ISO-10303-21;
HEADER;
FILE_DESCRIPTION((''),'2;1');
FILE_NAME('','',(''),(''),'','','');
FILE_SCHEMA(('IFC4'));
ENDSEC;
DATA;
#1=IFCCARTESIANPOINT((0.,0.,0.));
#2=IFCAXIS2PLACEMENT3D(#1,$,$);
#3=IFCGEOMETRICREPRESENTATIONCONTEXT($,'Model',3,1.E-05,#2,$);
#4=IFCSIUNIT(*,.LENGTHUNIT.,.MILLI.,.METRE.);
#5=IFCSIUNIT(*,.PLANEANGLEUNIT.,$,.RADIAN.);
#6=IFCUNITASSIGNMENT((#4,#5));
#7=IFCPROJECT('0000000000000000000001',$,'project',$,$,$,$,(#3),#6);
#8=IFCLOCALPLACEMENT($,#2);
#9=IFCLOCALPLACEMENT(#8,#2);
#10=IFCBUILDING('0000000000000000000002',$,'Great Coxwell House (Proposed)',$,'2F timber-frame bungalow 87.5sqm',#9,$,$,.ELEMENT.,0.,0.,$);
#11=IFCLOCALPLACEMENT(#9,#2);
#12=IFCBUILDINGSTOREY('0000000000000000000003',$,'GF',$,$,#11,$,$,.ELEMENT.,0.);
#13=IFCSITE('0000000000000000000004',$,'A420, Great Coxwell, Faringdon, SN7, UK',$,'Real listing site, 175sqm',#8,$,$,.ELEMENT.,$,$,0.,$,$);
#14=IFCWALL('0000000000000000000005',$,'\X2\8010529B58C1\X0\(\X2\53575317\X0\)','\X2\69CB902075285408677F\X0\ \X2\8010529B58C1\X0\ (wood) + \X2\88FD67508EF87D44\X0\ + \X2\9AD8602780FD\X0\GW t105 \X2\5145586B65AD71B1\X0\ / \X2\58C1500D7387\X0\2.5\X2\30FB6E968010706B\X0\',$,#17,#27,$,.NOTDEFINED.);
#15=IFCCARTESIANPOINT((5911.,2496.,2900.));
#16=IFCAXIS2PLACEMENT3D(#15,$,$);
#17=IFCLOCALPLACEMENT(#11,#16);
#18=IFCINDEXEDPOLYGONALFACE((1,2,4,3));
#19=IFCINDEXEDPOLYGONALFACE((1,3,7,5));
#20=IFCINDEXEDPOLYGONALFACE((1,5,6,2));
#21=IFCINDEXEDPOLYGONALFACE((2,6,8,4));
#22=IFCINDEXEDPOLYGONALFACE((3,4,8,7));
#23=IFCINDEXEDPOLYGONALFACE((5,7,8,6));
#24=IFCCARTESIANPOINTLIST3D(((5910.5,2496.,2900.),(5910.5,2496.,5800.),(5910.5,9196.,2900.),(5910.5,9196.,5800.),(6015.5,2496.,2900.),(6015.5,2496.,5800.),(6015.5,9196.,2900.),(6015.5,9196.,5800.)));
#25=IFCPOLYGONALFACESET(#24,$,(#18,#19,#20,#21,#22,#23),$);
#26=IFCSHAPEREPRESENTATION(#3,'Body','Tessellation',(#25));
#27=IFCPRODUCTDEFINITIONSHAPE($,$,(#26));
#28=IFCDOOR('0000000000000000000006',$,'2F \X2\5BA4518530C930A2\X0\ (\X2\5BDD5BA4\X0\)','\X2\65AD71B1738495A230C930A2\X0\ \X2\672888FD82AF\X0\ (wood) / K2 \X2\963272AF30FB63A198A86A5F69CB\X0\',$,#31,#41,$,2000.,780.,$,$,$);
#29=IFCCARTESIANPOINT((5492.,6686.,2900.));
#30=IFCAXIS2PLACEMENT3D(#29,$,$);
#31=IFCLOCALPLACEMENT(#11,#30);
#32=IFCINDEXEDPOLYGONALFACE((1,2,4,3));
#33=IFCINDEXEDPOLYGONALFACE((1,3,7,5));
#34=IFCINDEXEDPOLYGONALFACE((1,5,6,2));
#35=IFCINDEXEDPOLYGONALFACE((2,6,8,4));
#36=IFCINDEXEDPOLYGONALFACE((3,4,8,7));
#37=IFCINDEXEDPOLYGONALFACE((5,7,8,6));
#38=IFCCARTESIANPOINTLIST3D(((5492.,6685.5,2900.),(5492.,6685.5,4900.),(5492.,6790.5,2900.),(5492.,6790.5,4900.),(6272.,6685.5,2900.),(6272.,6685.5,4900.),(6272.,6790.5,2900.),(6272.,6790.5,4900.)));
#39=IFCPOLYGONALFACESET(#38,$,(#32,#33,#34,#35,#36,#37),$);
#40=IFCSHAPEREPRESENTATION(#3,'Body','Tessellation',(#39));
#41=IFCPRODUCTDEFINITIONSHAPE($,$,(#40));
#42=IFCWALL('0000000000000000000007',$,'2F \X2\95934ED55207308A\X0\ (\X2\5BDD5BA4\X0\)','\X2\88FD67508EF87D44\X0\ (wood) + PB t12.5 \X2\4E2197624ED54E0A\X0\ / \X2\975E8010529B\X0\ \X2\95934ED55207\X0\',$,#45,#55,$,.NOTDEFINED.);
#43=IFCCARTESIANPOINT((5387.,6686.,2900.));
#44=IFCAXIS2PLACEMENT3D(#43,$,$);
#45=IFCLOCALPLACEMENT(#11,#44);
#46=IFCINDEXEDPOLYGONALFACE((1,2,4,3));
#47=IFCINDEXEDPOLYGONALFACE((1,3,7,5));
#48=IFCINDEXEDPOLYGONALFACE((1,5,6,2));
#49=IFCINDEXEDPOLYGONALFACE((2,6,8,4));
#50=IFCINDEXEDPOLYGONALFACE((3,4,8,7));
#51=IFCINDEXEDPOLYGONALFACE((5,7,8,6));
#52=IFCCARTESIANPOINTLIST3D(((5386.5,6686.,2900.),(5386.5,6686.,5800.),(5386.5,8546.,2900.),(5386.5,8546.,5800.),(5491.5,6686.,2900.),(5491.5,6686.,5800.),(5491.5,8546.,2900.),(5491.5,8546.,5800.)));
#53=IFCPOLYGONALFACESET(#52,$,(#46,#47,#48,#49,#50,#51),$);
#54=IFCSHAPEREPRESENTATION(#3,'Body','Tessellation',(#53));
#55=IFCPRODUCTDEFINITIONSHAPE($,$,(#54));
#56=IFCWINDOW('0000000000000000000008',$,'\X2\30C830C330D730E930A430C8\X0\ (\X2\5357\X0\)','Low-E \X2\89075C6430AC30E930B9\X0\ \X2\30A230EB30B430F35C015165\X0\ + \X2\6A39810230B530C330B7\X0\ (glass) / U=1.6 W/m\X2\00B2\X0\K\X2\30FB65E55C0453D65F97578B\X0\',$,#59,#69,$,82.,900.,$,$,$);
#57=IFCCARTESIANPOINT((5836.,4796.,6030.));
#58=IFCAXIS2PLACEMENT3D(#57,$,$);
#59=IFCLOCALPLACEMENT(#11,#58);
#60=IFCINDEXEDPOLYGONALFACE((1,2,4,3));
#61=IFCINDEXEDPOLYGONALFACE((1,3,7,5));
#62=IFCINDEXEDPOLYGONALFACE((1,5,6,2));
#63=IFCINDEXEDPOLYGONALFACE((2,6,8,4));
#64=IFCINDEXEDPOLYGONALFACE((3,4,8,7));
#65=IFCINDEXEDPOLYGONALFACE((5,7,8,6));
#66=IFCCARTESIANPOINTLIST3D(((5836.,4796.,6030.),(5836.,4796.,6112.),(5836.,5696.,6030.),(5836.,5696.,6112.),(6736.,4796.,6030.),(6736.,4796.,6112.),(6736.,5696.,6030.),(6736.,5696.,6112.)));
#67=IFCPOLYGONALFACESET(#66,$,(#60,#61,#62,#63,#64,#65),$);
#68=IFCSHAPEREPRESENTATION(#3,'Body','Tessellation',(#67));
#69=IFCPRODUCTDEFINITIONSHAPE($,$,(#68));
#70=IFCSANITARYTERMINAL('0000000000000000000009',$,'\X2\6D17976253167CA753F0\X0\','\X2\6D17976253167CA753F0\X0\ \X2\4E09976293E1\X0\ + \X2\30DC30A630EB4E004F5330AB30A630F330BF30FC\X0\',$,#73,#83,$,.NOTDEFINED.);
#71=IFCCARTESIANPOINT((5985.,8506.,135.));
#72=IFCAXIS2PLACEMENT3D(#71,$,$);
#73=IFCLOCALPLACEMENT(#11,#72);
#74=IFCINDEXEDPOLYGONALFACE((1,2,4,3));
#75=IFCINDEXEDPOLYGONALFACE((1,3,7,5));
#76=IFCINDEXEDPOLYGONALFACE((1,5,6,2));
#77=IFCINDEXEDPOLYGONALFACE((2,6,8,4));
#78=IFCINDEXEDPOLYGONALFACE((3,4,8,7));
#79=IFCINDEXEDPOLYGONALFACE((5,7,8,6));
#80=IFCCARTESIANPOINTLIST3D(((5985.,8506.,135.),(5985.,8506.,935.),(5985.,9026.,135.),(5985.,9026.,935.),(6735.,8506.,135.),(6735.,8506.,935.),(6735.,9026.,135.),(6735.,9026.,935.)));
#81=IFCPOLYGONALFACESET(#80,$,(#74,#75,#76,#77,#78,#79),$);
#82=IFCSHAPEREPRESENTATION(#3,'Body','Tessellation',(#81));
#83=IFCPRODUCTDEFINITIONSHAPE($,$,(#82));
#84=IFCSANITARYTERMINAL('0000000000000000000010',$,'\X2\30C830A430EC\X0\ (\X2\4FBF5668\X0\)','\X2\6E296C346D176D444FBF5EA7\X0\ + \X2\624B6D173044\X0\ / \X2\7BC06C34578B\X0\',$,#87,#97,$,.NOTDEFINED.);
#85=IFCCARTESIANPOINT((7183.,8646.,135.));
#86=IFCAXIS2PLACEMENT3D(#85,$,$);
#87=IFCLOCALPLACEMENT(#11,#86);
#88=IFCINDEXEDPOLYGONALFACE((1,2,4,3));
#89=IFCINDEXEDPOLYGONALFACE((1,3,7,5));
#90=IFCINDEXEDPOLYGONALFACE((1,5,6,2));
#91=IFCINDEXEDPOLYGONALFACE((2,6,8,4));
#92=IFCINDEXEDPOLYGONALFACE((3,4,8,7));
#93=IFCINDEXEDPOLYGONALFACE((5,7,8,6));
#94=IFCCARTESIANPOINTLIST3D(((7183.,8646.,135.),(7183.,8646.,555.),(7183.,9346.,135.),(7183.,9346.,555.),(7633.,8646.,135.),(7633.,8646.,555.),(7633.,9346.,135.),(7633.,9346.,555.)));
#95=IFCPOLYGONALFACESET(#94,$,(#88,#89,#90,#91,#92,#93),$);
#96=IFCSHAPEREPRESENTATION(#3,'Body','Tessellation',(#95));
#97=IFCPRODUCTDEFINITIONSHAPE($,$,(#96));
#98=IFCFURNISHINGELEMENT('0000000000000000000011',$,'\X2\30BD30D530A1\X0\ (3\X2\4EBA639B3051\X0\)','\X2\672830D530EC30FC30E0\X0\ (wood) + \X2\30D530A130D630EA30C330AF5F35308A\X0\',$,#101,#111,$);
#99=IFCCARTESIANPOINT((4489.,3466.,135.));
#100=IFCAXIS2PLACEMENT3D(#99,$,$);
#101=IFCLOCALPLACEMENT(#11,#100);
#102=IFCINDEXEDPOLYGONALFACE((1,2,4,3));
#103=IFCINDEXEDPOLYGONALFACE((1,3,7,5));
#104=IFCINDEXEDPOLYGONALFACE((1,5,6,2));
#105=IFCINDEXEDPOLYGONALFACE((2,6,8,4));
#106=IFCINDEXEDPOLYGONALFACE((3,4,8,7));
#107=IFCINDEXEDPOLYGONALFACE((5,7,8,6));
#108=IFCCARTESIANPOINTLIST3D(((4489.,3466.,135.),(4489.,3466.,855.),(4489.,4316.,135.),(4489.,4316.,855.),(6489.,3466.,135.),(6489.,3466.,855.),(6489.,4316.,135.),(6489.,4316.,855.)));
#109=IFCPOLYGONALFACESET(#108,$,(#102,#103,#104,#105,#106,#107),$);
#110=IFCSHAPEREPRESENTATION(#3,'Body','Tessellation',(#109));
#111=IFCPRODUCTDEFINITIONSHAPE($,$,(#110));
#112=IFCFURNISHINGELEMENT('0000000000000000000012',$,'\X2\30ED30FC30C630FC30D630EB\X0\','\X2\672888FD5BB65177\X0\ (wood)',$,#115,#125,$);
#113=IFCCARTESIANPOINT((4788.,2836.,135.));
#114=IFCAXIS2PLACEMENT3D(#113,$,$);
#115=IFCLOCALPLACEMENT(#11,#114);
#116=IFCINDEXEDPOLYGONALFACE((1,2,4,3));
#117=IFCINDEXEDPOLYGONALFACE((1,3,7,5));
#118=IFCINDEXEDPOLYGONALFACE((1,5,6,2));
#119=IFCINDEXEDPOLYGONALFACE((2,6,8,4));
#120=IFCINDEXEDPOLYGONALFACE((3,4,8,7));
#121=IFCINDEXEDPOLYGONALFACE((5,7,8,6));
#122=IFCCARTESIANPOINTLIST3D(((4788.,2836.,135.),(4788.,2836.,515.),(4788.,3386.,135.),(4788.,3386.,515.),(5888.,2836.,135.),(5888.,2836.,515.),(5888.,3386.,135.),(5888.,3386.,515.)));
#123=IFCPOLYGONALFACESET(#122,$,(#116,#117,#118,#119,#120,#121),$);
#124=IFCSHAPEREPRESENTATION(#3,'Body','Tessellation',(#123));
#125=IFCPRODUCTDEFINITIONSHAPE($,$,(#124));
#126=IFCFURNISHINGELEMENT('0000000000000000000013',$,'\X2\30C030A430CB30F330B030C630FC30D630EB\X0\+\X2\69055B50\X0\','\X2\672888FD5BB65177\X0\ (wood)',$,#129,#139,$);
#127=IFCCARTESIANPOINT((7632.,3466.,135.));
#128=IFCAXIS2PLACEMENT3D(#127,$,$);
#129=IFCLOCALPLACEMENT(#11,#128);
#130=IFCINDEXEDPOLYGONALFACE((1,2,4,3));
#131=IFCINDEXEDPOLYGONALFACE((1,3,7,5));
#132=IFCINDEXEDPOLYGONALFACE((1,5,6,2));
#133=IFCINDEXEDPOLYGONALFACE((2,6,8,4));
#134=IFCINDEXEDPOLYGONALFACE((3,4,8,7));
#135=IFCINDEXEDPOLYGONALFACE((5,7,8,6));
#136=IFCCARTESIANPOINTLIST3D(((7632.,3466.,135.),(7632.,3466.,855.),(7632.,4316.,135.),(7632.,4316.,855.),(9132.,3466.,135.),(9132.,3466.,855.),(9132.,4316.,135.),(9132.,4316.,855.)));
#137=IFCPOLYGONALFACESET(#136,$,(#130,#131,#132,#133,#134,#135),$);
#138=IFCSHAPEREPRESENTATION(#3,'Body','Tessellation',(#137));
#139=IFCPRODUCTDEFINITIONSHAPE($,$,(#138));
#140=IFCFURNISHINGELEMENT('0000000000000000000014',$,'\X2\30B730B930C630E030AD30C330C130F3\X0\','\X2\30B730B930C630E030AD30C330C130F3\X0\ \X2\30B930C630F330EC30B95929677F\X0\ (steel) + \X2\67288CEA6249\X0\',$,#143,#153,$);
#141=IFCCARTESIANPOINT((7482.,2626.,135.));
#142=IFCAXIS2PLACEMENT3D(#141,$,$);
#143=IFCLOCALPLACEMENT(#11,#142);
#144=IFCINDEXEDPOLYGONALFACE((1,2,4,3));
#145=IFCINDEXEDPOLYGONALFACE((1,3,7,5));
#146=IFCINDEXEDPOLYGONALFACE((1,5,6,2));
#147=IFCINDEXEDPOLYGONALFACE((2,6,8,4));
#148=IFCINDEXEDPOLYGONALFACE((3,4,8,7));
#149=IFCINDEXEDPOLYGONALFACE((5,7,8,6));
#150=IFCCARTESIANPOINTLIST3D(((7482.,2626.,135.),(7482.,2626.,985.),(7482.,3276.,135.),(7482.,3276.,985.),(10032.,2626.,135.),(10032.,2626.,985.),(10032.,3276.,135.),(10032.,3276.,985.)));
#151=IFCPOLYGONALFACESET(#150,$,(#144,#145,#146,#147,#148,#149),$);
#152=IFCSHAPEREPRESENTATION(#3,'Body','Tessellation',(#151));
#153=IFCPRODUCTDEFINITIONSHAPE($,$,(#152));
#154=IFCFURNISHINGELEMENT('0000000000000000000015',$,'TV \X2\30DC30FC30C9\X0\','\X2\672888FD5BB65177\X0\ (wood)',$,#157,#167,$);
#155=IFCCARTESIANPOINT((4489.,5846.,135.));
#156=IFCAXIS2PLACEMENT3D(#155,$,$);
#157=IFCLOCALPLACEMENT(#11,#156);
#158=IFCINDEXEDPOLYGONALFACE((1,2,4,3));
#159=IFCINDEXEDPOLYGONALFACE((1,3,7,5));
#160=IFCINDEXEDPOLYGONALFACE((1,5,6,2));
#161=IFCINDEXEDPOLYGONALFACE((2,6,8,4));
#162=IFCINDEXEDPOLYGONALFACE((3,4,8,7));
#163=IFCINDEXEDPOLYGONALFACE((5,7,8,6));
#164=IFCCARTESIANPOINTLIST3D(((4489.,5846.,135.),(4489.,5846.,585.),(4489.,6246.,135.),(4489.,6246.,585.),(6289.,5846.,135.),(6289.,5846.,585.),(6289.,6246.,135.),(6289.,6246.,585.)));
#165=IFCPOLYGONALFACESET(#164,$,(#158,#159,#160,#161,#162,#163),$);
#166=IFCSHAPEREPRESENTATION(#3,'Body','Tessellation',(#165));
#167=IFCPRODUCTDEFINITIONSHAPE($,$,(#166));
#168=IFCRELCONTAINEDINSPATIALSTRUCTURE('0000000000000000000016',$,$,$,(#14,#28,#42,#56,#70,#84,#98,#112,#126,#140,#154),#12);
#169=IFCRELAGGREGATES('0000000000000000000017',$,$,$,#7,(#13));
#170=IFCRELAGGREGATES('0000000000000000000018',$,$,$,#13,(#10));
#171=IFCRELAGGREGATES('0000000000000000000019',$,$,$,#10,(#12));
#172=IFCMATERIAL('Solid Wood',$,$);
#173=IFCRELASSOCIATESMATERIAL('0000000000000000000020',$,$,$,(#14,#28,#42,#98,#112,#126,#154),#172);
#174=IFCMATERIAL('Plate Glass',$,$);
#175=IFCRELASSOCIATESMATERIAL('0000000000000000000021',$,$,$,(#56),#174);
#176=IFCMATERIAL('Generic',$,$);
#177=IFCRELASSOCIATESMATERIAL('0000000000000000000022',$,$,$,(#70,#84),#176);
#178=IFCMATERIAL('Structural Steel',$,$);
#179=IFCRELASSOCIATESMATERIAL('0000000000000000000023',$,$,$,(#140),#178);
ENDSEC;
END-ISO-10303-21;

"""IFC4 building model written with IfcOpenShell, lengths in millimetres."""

from ifc_helpers import new_model, si_unit, frame, frame_2d, origin, place, context, project, spatial, rectangle, extrude, material, element, fill, save


model = new_model("IFC4")

# Units and contexts
model_context = context("Model", 3, precision=1e-05, world=origin())
ifc_project = project(units=[si_unit("LENGTHUNIT", "METRE", prefix="MILLI"), si_unit("PLANEANGLEUNIT", "RADIAN")], contexts=[model_context])

# Site, building, storey
site_placement = place(None, origin())
site = spatial("IfcSite", under=ifc_project, at=site_placement, Name="A420, Great Coxwell, Faringdon, SN7, UK", ObjectType="Real listing site, 175sqm", CompositionType="ELEMENT", RefElevation=0.0)
building_placement = place(site_placement, origin())
building = spatial("IfcBuilding", under=site, at=building_placement, Name="Great Coxwell House (Proposed)", ObjectType="2F timber-frame bungalow 87.5sqm", CompositionType="ELEMENT", ElevationOfRefHeight=0.0, ElevationOfTerrain=0.0)
storey_placement = place(building_placement, origin())
storey = spatial("IfcBuildingStorey", under=building, at=storey_placement, Name="GF", CompositionType="ELEMENT", Elevation=0.0)

# Shared definitions
ifc_material_1 = material(Name="Solid Wood")

# Wall, opening, door
wall_1_placement = place(storey_placement, frame((5911.0, 2496.0, 2900.0)))
wall_1 = element("IfcWall", 1, at=wall_1_placement, inside=storey, material=ifc_material_1, Name="耐力壁(南北)", Description="構造用合板 耐力壁 (wood) + 製材軸組 + 高性能GW t105 充填断熱 / 壁倍率2.5・準耐火", PredefinedType="NOTDEFINED", context=model_context, shape_type="SweptSolid", body=[
    extrude(rectangle(XDim=105.0, YDim=6700.0, at=frame_2d((52.0, 3350.0))), frame((5911.0, 2496.0, 2900.0)), (0.0, 0.0, 1.0), 2900.0),
])
opening_1_placement = place(storey_placement, frame((5492.0, 6686.0, 2900.0)))
opening_1 = element("IfcOpeningElement", 2, at=opening_1_placement, cuts=wall_1, PredefinedType="NOTDEFINED", context=model_context, shape_type="SweptSolid", body=[
    extrude(rectangle(XDim=780.0, YDim=105.0, at=frame_2d((390.0, 52.0))), frame((5492.0, 6686.0, 2900.0)), (0.0, 0.0, 1.0), 2000.0),
])
door_1_placement = place(storey_placement, frame((5492.0, 6686.0, 2900.0)))
door_1 = element("IfcDoor", 3, at=door_1_placement, inside=storey, material=ifc_material_1, Name="2F 室内ドア (寝室)", Description="断熱玄関ドア 木製芯 (wood) / K2 防犯・採風機構", OverallHeight=2000.0, OverallWidth=780.0, context=model_context, shape_type="SweptSolid", body=[
    extrude(rectangle(XDim=780.0, YDim=105.0, at=frame_2d((390.0, 52.0))), frame((5492.0, 6686.0, 2900.0)), (0.0, 0.0, 1.0), 2000.0),
])
fill(opening_1, door_1)

# Wall
wall_2_placement = place(storey_placement, frame((5387.0, 6686.0, 2900.0)))
element("IfcWall", 4, at=wall_2_placement, inside=storey, material=ifc_material_1, Name="2F 間仕切り (寝室)", Description="製材軸組 (wood) + PB t12.5 両面仕上 / 非耐力 間仕切", PredefinedType="NOTDEFINED", context=model_context, shape_type="SweptSolid", body=[
    extrude(rectangle(XDim=105.0, YDim=1860.0, at=frame_2d((52.0, 930.0))), frame((5387.0, 6686.0, 2900.0)), (0.0, 0.0, 1.0), 2900.0),
])

# Window
ifc_material_2 = material(Name="Plate Glass")
window_placement = place(storey_placement, frame((5836.0, 4796.0, 6030.0)))
element("IfcWindow", 5, at=window_placement, inside=storey, material=ifc_material_2, Name="トップライト (南)", Description="Low-E 複層ガラス アルゴン封入 + 樹脂サッシ (glass) / U=1.6 W/m²K・日射取得型", OverallHeight=82.0, OverallWidth=900.0, context=model_context, shape_type="SweptSolid", body=[
    extrude(rectangle(XDim=900.0, YDim=900.0, at=frame_2d((450.0, 450.0))), frame((5836.0, 4796.0, 6030.0)), (0.0, 0.0, 1.0), 82.0),
])

# Sanitary terminals
ifc_material_3 = material(Name="Generic")
sanitary_terminal_1_placement = place(storey_placement, frame((5985.0, 8506.0, 135.0)))
element("IfcSanitaryTerminal", 6, at=sanitary_terminal_1_placement, inside=storey, material=ifc_material_3, Name="洗面化粧台", Description="洗面化粧台 三面鏡 + ボウル一体カウンター", PredefinedType="NOTDEFINED", context=model_context, shape_type="SweptSolid", body=[
    extrude(rectangle(XDim=750.0, YDim=520.0, at=frame_2d((375.0, 260.0))), frame((5985.0, 8506.0, 135.0)), (0.0, 0.0, 1.0), 800.0),
])
sanitary_terminal_2_placement = place(storey_placement, frame((7183.0, 8646.0, 135.0)))
element("IfcSanitaryTerminal", 7, at=sanitary_terminal_2_placement, inside=storey, material=ifc_material_3, Name="トイレ (便器)", Description="温水洗浄便座 + 手洗い / 節水型", PredefinedType="NOTDEFINED", context=model_context, shape_type="SweptSolid", body=[
    extrude(rectangle(XDim=450.0, YDim=700.0, at=frame_2d((225.0, 350.0))), frame((7183.0, 8646.0, 135.0)), (0.0, 0.0, 1.0), 420.0),
])

# Furnishing elements
furnishing_1_placement = place(storey_placement, frame((4489.0, 3466.0, 135.0)))
element("IfcFurnishingElement", 8, at=furnishing_1_placement, inside=storey, material=ifc_material_1, Name="ソファ (3人掛け)", Description="木フレーム (wood) + ファブリック張り", context=model_context, shape_type="SweptSolid", body=[
    extrude(rectangle(XDim=2000.0, YDim=850.0, at=frame_2d((1000.0, 425.0))), frame((4489.0, 3466.0, 135.0)), (0.0, 0.0, 1.0), 720.0),
])
furnishing_2_placement = place(storey_placement, frame((4788.0, 2836.0, 135.0)))
element("IfcFurnishingElement", 9, at=furnishing_2_placement, inside=storey, material=ifc_material_1, Name="ローテーブル", Description="木製家具 (wood)", context=model_context, shape_type="SweptSolid", body=[
    extrude(rectangle(XDim=1100.0, YDim=550.0, at=frame_2d((550.0, 275.0))), frame((4788.0, 2836.0, 135.0)), (0.0, 0.0, 1.0), 380.0),
])
furnishing_3_placement = place(storey_placement, frame((7632.0, 3466.0, 135.0)))
element("IfcFurnishingElement", 10, at=furnishing_3_placement, inside=storey, material=ifc_material_1, Name="ダイニングテーブル+椅子", Description="木製家具 (wood)", context=model_context, shape_type="SweptSolid", body=[
    extrude(rectangle(XDim=1500.0, YDim=850.0, at=frame_2d((750.0, 425.0))), frame((7632.0, 3466.0, 135.0)), (0.0, 0.0, 1.0), 720.0),
])
ifc_material_4 = material(Name="Structural Steel")
furnishing_4_placement = place(storey_placement, frame((7482.0, 2626.0, 135.0)))
element("IfcFurnishingElement", 11, at=furnishing_4_placement, inside=storey, material=ifc_material_4, Name="システムキッチン", Description="システムキッチン ステンレス天板 (steel) + 木質扉", context=model_context, shape_type="SweptSolid", body=[
    extrude(rectangle(XDim=2550.0, YDim=650.0, at=frame_2d((1275.0, 325.0))), frame((7482.0, 2626.0, 135.0)), (0.0, 0.0, 1.0), 850.0),
])
furnishing_5_placement = place(storey_placement, frame((4489.0, 5846.0, 135.0)))
element("IfcFurnishingElement", 12, at=furnishing_5_placement, inside=storey, material=ifc_material_1, Name="TV ボード", Description="木製家具 (wood)", context=model_context, shape_type="SweptSolid", body=[
    extrude(rectangle(XDim=1800.0, YDim=400.0, at=frame_2d((900.0, 200.0))), frame((4489.0, 5846.0, 135.0)), (0.0, 0.0, 1.0), 450.0),
])

save(model, "model.ifc")
